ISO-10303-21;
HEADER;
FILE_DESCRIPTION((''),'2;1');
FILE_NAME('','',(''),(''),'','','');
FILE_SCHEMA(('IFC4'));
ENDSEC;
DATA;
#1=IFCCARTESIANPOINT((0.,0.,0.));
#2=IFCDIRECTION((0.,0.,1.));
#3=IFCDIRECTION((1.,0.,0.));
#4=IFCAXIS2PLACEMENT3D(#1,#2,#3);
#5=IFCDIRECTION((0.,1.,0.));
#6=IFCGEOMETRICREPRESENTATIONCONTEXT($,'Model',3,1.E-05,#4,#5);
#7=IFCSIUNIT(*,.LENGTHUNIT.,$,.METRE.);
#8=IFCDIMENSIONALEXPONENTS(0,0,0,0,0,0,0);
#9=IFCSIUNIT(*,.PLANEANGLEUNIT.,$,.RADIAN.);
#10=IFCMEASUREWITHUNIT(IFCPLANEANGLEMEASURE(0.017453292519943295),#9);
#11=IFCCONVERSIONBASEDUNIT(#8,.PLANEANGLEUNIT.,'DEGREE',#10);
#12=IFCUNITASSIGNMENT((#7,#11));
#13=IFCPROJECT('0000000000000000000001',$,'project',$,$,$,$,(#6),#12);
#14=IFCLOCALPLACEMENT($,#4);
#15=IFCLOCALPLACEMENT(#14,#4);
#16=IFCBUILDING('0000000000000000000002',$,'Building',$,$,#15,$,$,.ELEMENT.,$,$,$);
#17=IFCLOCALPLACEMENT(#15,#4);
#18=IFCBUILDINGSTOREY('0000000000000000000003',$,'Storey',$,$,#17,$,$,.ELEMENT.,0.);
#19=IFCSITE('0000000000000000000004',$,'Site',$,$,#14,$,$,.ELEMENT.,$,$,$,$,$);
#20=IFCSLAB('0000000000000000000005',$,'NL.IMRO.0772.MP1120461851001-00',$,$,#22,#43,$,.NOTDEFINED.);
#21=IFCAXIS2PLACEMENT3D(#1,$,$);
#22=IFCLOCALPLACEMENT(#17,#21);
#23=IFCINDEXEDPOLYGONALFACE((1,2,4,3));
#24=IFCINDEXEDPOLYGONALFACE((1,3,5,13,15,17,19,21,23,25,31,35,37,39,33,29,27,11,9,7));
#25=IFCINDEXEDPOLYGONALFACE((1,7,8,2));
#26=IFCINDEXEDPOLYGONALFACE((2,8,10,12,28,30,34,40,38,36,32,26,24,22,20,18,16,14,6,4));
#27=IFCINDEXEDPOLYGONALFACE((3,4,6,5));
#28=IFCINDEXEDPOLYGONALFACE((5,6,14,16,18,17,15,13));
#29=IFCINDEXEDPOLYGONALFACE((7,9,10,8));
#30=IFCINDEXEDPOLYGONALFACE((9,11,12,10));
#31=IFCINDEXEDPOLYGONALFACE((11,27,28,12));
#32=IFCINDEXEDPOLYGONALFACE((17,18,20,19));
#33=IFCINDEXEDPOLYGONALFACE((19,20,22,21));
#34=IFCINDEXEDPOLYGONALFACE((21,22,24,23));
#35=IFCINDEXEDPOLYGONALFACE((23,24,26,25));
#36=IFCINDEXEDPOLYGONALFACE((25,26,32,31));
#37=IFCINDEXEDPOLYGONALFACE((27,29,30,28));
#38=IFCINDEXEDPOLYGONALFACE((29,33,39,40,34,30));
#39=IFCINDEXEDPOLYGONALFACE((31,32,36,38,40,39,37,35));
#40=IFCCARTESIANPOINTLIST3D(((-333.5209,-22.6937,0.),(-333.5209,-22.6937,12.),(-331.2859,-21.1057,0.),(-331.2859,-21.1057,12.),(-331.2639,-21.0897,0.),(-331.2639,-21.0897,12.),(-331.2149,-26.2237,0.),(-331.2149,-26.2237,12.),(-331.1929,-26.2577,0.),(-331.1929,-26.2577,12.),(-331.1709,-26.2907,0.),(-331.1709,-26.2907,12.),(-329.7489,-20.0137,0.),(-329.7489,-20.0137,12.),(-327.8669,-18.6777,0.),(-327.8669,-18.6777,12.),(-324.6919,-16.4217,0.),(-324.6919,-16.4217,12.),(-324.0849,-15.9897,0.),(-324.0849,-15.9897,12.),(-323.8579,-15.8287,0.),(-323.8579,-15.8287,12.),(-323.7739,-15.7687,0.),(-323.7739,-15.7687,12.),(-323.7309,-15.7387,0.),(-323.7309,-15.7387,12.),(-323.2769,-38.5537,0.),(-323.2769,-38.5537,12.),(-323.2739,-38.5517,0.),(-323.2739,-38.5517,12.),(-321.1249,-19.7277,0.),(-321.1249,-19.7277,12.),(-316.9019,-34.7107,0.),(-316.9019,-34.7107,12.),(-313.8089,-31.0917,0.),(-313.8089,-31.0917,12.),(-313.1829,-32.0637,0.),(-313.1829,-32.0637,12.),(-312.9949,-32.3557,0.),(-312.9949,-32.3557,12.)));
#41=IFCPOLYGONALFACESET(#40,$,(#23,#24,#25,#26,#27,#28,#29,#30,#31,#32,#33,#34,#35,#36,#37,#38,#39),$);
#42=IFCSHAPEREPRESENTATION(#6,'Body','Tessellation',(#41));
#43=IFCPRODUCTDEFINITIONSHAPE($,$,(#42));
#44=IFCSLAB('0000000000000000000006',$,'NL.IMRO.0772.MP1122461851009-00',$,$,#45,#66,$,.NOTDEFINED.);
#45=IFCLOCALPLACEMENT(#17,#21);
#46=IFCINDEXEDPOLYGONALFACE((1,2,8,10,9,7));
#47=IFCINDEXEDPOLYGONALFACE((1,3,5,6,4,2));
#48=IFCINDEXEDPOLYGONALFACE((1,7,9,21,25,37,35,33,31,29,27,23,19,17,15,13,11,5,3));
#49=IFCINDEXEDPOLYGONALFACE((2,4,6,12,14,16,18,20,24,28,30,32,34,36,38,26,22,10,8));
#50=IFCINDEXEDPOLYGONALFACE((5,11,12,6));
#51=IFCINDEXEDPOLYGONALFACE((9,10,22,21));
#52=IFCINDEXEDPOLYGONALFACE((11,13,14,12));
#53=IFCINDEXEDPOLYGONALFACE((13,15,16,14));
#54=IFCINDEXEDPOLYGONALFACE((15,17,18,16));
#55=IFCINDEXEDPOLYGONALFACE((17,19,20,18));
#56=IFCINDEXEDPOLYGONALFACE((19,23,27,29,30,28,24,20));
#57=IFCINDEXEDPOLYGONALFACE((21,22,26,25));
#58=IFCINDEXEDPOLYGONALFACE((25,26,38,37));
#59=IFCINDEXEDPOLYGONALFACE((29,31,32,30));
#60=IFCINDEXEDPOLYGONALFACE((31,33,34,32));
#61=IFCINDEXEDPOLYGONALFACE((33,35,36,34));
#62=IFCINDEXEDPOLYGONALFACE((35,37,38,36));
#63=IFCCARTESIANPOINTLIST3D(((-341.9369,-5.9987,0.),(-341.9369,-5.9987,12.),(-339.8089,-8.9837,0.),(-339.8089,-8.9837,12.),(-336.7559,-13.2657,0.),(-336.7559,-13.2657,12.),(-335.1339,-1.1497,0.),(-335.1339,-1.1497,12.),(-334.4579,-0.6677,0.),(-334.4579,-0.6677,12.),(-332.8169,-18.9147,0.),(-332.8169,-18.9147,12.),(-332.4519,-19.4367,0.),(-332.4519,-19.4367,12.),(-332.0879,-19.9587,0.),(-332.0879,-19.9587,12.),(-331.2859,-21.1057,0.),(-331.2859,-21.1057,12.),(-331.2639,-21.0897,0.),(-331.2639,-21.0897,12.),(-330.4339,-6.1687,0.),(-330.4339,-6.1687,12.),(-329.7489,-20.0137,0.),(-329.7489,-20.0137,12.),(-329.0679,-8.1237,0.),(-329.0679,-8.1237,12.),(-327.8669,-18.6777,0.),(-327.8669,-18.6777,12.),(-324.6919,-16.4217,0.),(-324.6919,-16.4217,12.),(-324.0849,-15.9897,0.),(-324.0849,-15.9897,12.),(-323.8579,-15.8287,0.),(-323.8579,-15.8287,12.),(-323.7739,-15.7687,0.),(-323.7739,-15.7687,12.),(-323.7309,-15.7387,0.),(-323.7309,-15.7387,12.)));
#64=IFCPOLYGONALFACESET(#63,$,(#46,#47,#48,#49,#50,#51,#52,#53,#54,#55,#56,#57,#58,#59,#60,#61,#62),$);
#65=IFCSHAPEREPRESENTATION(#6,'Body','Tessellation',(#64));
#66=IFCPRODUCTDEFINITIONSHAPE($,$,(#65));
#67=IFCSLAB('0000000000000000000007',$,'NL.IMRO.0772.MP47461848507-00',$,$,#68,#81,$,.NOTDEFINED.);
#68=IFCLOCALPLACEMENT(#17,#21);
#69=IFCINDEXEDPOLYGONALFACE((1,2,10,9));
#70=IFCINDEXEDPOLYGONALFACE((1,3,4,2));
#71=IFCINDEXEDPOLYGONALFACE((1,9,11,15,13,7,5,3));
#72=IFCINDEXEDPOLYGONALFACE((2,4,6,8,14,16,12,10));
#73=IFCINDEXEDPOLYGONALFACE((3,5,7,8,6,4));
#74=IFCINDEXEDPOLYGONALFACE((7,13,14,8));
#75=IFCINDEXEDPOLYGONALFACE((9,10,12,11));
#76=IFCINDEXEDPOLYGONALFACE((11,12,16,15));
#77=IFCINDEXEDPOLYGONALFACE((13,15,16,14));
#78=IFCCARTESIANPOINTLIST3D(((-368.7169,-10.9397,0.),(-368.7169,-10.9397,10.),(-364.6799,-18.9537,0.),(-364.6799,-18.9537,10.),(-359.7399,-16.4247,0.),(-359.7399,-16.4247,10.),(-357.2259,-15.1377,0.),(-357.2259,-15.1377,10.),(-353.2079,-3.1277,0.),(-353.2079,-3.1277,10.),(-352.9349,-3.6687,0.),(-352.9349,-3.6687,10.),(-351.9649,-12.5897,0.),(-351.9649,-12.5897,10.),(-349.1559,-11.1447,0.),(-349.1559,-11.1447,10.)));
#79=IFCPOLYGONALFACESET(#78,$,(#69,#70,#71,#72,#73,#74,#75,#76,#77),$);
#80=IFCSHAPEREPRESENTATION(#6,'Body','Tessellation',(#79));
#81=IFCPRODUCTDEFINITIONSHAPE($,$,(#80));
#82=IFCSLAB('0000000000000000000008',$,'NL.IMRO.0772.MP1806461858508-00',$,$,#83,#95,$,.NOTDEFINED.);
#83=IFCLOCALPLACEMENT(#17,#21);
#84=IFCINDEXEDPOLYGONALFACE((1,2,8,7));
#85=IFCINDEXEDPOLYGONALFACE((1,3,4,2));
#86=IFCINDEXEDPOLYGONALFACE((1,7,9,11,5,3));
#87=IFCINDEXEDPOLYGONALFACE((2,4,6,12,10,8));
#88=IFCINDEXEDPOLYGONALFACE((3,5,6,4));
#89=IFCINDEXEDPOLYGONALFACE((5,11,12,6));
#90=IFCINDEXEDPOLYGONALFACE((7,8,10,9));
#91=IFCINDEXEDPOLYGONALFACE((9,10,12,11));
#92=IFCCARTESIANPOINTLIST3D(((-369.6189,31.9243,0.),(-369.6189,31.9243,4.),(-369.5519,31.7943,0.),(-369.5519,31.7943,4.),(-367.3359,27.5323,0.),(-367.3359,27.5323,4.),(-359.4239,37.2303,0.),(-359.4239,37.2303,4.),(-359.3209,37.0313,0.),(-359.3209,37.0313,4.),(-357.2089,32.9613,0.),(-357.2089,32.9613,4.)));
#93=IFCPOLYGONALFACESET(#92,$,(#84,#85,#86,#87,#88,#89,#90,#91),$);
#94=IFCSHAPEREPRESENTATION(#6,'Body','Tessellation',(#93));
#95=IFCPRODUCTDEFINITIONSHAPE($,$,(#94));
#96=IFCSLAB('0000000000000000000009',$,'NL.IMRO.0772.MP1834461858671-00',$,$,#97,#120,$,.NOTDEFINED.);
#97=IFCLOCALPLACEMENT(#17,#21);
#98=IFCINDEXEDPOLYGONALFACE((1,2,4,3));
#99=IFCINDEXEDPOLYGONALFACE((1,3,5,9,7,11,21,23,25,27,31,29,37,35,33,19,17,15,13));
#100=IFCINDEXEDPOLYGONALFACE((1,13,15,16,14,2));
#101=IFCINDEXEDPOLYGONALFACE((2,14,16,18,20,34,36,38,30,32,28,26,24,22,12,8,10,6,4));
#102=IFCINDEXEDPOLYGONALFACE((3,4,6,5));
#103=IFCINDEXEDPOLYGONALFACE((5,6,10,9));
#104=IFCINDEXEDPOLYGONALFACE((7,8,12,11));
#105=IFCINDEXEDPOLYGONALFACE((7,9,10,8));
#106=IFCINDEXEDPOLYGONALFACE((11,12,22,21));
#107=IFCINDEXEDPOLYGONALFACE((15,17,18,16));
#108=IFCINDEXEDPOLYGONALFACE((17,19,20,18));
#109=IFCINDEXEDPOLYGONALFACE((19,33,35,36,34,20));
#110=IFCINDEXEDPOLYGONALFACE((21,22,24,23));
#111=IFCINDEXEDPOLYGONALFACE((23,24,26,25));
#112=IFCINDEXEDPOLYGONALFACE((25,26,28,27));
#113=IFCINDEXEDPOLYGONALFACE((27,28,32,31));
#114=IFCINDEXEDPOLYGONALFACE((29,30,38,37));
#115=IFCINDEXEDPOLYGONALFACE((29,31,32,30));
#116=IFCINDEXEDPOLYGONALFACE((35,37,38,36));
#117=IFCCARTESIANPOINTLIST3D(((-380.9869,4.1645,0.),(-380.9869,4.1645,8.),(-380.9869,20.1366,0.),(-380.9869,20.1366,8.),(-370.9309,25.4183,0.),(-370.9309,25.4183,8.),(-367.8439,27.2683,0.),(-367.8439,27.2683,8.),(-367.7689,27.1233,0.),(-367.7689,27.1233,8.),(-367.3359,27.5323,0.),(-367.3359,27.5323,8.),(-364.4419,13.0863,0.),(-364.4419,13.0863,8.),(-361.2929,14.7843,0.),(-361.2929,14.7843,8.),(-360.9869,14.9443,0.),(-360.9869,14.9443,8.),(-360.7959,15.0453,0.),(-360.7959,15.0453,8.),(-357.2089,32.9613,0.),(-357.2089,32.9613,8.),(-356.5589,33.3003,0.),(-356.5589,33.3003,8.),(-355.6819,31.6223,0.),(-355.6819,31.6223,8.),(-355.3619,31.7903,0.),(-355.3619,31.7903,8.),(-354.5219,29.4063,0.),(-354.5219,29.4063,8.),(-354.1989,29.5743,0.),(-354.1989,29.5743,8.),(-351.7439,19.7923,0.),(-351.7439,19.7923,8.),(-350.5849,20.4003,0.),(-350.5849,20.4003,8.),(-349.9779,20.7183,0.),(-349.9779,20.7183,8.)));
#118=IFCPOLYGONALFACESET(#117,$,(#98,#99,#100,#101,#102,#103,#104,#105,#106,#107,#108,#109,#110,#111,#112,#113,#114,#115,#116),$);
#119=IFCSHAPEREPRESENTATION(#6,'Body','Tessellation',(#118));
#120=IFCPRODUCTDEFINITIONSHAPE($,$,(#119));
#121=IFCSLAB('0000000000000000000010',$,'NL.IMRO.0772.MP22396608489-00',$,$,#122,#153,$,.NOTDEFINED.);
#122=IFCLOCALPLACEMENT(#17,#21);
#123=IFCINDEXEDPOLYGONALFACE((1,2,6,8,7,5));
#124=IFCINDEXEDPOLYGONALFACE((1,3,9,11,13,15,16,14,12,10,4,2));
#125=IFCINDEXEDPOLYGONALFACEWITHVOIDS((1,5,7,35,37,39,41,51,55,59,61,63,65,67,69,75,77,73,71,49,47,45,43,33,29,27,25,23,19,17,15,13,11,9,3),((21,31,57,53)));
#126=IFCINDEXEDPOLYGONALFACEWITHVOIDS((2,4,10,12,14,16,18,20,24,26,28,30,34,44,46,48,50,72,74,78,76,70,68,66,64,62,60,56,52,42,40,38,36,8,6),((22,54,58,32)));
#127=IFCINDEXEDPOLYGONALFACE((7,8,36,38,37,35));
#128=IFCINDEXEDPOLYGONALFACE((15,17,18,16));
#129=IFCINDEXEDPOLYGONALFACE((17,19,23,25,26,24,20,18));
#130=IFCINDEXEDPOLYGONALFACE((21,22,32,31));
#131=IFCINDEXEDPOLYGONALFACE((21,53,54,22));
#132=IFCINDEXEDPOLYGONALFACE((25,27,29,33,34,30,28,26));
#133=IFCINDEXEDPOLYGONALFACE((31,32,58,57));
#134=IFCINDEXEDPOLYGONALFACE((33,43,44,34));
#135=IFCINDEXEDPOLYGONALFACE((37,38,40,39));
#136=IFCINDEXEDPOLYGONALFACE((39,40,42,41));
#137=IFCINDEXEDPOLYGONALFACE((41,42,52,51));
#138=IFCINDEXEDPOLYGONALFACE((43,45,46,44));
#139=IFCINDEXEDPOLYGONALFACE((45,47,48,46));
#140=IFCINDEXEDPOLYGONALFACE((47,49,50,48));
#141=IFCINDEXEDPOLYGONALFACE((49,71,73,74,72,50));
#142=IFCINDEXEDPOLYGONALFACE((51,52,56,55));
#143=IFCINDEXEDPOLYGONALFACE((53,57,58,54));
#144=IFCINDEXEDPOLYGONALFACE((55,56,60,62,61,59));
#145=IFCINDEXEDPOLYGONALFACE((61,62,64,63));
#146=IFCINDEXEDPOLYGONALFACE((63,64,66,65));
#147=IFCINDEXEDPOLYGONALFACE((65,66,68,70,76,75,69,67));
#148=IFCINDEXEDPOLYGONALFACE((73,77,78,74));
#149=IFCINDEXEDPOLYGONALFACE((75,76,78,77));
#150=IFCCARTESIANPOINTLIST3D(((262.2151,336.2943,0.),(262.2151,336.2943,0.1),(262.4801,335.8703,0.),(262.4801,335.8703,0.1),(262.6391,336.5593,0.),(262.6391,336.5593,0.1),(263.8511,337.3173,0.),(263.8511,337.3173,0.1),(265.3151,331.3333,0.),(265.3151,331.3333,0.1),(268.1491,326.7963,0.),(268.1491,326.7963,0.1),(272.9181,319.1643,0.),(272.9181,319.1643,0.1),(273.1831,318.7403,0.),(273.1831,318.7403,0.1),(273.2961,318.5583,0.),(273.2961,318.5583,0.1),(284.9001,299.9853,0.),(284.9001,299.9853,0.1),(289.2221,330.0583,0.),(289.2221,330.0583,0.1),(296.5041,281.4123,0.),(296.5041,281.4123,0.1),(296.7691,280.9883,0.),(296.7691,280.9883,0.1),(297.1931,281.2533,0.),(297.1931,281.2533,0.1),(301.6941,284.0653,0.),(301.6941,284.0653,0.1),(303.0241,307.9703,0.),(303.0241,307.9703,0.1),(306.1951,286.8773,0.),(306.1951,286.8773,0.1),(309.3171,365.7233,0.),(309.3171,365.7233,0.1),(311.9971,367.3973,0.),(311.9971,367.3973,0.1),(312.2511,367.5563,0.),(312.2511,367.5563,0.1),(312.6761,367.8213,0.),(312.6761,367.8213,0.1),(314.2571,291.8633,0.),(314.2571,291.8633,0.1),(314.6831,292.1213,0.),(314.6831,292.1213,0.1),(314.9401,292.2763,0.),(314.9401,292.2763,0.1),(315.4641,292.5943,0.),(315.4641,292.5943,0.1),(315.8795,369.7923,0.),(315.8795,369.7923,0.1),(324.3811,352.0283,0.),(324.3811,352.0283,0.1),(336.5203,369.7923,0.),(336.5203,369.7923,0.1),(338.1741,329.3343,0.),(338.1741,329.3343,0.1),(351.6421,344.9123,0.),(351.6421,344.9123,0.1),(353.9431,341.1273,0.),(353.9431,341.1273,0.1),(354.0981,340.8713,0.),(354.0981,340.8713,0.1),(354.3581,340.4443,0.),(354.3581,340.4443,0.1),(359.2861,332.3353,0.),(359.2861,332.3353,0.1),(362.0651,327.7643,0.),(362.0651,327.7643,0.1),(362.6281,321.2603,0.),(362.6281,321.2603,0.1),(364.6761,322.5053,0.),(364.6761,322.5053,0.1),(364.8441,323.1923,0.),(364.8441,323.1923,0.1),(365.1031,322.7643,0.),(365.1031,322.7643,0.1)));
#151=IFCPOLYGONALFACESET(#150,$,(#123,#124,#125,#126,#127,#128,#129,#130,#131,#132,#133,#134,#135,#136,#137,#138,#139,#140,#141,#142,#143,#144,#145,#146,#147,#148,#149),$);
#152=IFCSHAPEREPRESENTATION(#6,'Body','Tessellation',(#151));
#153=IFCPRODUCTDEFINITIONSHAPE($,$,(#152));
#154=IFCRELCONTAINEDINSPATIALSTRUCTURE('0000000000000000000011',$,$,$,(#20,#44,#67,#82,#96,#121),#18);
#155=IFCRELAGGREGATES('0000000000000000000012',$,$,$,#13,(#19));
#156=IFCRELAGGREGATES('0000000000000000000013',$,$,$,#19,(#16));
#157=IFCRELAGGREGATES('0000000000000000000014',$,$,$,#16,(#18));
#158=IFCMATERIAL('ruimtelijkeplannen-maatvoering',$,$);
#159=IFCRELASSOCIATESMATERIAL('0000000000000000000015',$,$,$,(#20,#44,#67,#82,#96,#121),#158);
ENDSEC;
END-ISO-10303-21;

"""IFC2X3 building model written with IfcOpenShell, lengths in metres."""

from ifc_helpers import new_model, entity, si_unit, converted_unit, direction, origin_with_axes, place, context, project, spatial, polyline, outline, extrude, material, element, save


model = new_model("IFC2X3")

# Units and contexts
model_context = context("Model", 3, precision=1e-05, world=origin_with_axes(), true_north=direction((0.0, 1.0, 0.0)))
ifc_project = project(units=[si_unit("LENGTHUNIT", "METRE"), converted_unit("PLANEANGLEUNIT", "DEGREE", entity("IfcPlaneAngleMeasure", 0.017453292519943295), si_unit("PLANEANGLEUNIT", "RADIAN"), dimensions=[0, 0, 0, 0, 0, 0, 0])], contexts=[model_context])

# Site, building, storey
site_placement = place(None, origin_with_axes())
site = spatial("IfcSite", under=ifc_project, at=site_placement, Name="Site", CompositionType="ELEMENT")
building_placement = place(site_placement, origin_with_axes())
building = spatial("IfcBuilding", under=site, at=building_placement, Name="Building", CompositionType="ELEMENT")
storey_placement = place(building_placement, origin_with_axes())
storey = spatial("IfcBuildingStorey", under=building, at=storey_placement, Name="Storey", CompositionType="ELEMENT", Elevation=0.0)

# Slabs
ifc_material = material(Name="ruimtelijkeplannen-maatvoering")
slab_1_placement = place(storey_placement, origin_with_axes())
element("IfcSlab", 1, at=slab_1_placement, inside=storey, material=ifc_material, Name="NL.IMRO.0772.MP1120461851001-00", PredefinedType="NOTDEFINED", context=model_context, shape_type="SweptSolid", body=[
    extrude(outline(polyline([(-316.9019, -34.7107), (-323.2739, -38.5517), (-323.2769, -38.5537), (-331.1709, -26.2907), (-331.1929, -26.2577), (-331.2149, -26.2237), (-333.5209, -22.6937), (-331.2859, -21.1057), (-331.2639, -21.0897), (-329.7489, -20.0137), (-327.8669, -18.6777), (-324.6919, -16.4217), (-324.0849, -15.9897), (-323.8579, -15.8287), (-323.7739, -15.7687), (-323.7309, -15.7387), (-321.1249, -19.7277), (-313.8089, -31.0917), (-313.1829, -32.0637), (-312.9949, -32.3557), (-316.9019, -34.7107)])), origin_with_axes(), (0.0, 0.0, 1.0), 12.0),
])
slab_2_placement = place(storey_placement, origin_with_axes())
element("IfcSlab", 2, at=slab_2_placement, inside=storey, material=ifc_material, Name="NL.IMRO.0772.MP1122461851009-00", PredefinedType="NOTDEFINED", context=model_context, shape_type="SweptSolid", body=[
    extrude(outline(polyline([(-331.2859, -21.1057), (-332.0879, -19.9587), (-332.4519, -19.4367), (-332.8169, -18.9147), (-336.7559, -13.2657), (-339.8089, -8.9837), (-341.9369, -5.9987), (-335.1339, -1.1497), (-334.4579, -0.6677), (-330.4339, -6.1687), (-329.0679, -8.1237), (-323.7309, -15.7387), (-323.7739, -15.7687), (-323.8579, -15.8287), (-324.0849, -15.9897), (-324.6919, -16.4217), (-327.8669, -18.6777), (-329.7489, -20.0137), (-331.2639, -21.0897), (-331.2859, -21.1057)])), origin_with_axes(), (0.0, 0.0, 1.0), 12.0),
])
slab_3_placement = place(storey_placement, origin_with_axes())
element("IfcSlab", 3, at=slab_3_placement, inside=storey, material=ifc_material, Name="NL.IMRO.0772.MP47461848507-00", PredefinedType="NOTDEFINED", context=model_context, shape_type="SweptSolid", body=[
    extrude(outline(polyline([(-352.9349, -3.6687), (-349.1559, -11.1447), (-351.9649, -12.5897), (-357.2259, -15.1377), (-359.7399, -16.4247), (-364.6799, -18.9537), (-368.7169, -10.9397), (-353.2079, -3.1277), (-352.9349, -3.6687)])), origin_with_axes(), (0.0, 0.0, 1.0), 10.0),
])
slab_4_placement = place(storey_placement, origin_with_axes())
element("IfcSlab", 4, at=slab_4_placement, inside=storey, material=ifc_material, Name="NL.IMRO.0772.MP1806461858508-00", PredefinedType="NOTDEFINED", context=model_context, shape_type="SweptSolid", body=[
    extrude(outline(polyline([(-367.3359, 27.5323), (-369.5519, 31.7943), (-369.6189, 31.9243), (-359.4239, 37.2303), (-359.3209, 37.0313), (-357.2089, 32.9613), (-367.3359, 27.5323)])), origin_with_axes(), (0.0, 0.0, 1.0), 4.0),
])
slab_5_placement = place(storey_placement, origin_with_axes())
element("IfcSlab", 5, at=slab_5_placement, inside=storey, material=ifc_material, Name="NL.IMRO.0772.MP1834461858671-00", PredefinedType="NOTDEFINED", context=model_context, shape_type="SweptSolid", body=[
    extrude(outline(polyline([(-370.9309, 25.4183), (-367.7689, 27.1233), (-367.8439, 27.2683), (-367.3359, 27.5323), (-357.2089, 32.9613), (-356.5589, 33.3003), (-355.6819, 31.6223), (-355.3619, 31.7903), (-354.1989, 29.5743), (-354.5219, 29.4063), (-349.9779, 20.7183), (-350.5849, 20.4003), (-351.7439, 19.7923), (-360.7959, 15.0453), (-360.9869, 14.9443), (-361.2929, 14.7843), (-364.4419, 13.0863), (-380.9869, 4.1645), (-380.9869, 20.1366), (-370.9309, 25.4183)])), origin_with_axes(), (0.0, 0.0, 1.0), 8.0),
])
slab_6_placement = place(storey_placement, origin_with_axes())
element("IfcSlab", 6, at=slab_6_placement, inside=storey, material=ifc_material, Name="NL.IMRO.0772.MP22396608489-00", PredefinedType="NOTDEFINED", context=model_context, shape_type="SweptSolid", body=[
    extrude(outline(polyline([(351.6421, 344.9123), (353.9431, 341.1273), (354.0981, 340.8713), (354.3581, 340.4443), (359.2861, 332.3353), (362.0651, 327.7643), (364.8441, 323.1923), (365.1031, 322.7643), (364.6761, 322.5053), (362.6281, 321.2603), (315.4641, 292.5943), (314.9401, 292.2763), (314.6831, 292.1213), (314.2571, 291.8633), (306.1951, 286.8773), (301.6941, 284.0653), (297.1931, 281.2533), (296.7691, 280.9883), (296.5041, 281.4123), (284.9001, 299.9853), (273.2961, 318.5583), (273.1831, 318.7403), (272.9181, 319.1643), (268.1491, 326.7963), (265.3151, 331.3333), (262.4801, 335.8703), (262.2151, 336.2943), (262.6391, 336.5593), (263.8511, 337.3173), (309.3171, 365.7233), (311.9971, 367.3973), (312.2511, 367.5563), (312.6761, 367.8213), (315.8795, 369.7923), (336.5203, 369.7923), (351.6421, 344.9123)]), holes=[polyline([(303.0241, 307.9703), (338.1741, 329.3343), (324.3811, 352.0283), (289.2221, 330.0583), (303.0241, 307.9703)])]), origin_with_axes(), (0.0, 0.0, 1.0), 0.1),
])

save(model, "model.ifc")
